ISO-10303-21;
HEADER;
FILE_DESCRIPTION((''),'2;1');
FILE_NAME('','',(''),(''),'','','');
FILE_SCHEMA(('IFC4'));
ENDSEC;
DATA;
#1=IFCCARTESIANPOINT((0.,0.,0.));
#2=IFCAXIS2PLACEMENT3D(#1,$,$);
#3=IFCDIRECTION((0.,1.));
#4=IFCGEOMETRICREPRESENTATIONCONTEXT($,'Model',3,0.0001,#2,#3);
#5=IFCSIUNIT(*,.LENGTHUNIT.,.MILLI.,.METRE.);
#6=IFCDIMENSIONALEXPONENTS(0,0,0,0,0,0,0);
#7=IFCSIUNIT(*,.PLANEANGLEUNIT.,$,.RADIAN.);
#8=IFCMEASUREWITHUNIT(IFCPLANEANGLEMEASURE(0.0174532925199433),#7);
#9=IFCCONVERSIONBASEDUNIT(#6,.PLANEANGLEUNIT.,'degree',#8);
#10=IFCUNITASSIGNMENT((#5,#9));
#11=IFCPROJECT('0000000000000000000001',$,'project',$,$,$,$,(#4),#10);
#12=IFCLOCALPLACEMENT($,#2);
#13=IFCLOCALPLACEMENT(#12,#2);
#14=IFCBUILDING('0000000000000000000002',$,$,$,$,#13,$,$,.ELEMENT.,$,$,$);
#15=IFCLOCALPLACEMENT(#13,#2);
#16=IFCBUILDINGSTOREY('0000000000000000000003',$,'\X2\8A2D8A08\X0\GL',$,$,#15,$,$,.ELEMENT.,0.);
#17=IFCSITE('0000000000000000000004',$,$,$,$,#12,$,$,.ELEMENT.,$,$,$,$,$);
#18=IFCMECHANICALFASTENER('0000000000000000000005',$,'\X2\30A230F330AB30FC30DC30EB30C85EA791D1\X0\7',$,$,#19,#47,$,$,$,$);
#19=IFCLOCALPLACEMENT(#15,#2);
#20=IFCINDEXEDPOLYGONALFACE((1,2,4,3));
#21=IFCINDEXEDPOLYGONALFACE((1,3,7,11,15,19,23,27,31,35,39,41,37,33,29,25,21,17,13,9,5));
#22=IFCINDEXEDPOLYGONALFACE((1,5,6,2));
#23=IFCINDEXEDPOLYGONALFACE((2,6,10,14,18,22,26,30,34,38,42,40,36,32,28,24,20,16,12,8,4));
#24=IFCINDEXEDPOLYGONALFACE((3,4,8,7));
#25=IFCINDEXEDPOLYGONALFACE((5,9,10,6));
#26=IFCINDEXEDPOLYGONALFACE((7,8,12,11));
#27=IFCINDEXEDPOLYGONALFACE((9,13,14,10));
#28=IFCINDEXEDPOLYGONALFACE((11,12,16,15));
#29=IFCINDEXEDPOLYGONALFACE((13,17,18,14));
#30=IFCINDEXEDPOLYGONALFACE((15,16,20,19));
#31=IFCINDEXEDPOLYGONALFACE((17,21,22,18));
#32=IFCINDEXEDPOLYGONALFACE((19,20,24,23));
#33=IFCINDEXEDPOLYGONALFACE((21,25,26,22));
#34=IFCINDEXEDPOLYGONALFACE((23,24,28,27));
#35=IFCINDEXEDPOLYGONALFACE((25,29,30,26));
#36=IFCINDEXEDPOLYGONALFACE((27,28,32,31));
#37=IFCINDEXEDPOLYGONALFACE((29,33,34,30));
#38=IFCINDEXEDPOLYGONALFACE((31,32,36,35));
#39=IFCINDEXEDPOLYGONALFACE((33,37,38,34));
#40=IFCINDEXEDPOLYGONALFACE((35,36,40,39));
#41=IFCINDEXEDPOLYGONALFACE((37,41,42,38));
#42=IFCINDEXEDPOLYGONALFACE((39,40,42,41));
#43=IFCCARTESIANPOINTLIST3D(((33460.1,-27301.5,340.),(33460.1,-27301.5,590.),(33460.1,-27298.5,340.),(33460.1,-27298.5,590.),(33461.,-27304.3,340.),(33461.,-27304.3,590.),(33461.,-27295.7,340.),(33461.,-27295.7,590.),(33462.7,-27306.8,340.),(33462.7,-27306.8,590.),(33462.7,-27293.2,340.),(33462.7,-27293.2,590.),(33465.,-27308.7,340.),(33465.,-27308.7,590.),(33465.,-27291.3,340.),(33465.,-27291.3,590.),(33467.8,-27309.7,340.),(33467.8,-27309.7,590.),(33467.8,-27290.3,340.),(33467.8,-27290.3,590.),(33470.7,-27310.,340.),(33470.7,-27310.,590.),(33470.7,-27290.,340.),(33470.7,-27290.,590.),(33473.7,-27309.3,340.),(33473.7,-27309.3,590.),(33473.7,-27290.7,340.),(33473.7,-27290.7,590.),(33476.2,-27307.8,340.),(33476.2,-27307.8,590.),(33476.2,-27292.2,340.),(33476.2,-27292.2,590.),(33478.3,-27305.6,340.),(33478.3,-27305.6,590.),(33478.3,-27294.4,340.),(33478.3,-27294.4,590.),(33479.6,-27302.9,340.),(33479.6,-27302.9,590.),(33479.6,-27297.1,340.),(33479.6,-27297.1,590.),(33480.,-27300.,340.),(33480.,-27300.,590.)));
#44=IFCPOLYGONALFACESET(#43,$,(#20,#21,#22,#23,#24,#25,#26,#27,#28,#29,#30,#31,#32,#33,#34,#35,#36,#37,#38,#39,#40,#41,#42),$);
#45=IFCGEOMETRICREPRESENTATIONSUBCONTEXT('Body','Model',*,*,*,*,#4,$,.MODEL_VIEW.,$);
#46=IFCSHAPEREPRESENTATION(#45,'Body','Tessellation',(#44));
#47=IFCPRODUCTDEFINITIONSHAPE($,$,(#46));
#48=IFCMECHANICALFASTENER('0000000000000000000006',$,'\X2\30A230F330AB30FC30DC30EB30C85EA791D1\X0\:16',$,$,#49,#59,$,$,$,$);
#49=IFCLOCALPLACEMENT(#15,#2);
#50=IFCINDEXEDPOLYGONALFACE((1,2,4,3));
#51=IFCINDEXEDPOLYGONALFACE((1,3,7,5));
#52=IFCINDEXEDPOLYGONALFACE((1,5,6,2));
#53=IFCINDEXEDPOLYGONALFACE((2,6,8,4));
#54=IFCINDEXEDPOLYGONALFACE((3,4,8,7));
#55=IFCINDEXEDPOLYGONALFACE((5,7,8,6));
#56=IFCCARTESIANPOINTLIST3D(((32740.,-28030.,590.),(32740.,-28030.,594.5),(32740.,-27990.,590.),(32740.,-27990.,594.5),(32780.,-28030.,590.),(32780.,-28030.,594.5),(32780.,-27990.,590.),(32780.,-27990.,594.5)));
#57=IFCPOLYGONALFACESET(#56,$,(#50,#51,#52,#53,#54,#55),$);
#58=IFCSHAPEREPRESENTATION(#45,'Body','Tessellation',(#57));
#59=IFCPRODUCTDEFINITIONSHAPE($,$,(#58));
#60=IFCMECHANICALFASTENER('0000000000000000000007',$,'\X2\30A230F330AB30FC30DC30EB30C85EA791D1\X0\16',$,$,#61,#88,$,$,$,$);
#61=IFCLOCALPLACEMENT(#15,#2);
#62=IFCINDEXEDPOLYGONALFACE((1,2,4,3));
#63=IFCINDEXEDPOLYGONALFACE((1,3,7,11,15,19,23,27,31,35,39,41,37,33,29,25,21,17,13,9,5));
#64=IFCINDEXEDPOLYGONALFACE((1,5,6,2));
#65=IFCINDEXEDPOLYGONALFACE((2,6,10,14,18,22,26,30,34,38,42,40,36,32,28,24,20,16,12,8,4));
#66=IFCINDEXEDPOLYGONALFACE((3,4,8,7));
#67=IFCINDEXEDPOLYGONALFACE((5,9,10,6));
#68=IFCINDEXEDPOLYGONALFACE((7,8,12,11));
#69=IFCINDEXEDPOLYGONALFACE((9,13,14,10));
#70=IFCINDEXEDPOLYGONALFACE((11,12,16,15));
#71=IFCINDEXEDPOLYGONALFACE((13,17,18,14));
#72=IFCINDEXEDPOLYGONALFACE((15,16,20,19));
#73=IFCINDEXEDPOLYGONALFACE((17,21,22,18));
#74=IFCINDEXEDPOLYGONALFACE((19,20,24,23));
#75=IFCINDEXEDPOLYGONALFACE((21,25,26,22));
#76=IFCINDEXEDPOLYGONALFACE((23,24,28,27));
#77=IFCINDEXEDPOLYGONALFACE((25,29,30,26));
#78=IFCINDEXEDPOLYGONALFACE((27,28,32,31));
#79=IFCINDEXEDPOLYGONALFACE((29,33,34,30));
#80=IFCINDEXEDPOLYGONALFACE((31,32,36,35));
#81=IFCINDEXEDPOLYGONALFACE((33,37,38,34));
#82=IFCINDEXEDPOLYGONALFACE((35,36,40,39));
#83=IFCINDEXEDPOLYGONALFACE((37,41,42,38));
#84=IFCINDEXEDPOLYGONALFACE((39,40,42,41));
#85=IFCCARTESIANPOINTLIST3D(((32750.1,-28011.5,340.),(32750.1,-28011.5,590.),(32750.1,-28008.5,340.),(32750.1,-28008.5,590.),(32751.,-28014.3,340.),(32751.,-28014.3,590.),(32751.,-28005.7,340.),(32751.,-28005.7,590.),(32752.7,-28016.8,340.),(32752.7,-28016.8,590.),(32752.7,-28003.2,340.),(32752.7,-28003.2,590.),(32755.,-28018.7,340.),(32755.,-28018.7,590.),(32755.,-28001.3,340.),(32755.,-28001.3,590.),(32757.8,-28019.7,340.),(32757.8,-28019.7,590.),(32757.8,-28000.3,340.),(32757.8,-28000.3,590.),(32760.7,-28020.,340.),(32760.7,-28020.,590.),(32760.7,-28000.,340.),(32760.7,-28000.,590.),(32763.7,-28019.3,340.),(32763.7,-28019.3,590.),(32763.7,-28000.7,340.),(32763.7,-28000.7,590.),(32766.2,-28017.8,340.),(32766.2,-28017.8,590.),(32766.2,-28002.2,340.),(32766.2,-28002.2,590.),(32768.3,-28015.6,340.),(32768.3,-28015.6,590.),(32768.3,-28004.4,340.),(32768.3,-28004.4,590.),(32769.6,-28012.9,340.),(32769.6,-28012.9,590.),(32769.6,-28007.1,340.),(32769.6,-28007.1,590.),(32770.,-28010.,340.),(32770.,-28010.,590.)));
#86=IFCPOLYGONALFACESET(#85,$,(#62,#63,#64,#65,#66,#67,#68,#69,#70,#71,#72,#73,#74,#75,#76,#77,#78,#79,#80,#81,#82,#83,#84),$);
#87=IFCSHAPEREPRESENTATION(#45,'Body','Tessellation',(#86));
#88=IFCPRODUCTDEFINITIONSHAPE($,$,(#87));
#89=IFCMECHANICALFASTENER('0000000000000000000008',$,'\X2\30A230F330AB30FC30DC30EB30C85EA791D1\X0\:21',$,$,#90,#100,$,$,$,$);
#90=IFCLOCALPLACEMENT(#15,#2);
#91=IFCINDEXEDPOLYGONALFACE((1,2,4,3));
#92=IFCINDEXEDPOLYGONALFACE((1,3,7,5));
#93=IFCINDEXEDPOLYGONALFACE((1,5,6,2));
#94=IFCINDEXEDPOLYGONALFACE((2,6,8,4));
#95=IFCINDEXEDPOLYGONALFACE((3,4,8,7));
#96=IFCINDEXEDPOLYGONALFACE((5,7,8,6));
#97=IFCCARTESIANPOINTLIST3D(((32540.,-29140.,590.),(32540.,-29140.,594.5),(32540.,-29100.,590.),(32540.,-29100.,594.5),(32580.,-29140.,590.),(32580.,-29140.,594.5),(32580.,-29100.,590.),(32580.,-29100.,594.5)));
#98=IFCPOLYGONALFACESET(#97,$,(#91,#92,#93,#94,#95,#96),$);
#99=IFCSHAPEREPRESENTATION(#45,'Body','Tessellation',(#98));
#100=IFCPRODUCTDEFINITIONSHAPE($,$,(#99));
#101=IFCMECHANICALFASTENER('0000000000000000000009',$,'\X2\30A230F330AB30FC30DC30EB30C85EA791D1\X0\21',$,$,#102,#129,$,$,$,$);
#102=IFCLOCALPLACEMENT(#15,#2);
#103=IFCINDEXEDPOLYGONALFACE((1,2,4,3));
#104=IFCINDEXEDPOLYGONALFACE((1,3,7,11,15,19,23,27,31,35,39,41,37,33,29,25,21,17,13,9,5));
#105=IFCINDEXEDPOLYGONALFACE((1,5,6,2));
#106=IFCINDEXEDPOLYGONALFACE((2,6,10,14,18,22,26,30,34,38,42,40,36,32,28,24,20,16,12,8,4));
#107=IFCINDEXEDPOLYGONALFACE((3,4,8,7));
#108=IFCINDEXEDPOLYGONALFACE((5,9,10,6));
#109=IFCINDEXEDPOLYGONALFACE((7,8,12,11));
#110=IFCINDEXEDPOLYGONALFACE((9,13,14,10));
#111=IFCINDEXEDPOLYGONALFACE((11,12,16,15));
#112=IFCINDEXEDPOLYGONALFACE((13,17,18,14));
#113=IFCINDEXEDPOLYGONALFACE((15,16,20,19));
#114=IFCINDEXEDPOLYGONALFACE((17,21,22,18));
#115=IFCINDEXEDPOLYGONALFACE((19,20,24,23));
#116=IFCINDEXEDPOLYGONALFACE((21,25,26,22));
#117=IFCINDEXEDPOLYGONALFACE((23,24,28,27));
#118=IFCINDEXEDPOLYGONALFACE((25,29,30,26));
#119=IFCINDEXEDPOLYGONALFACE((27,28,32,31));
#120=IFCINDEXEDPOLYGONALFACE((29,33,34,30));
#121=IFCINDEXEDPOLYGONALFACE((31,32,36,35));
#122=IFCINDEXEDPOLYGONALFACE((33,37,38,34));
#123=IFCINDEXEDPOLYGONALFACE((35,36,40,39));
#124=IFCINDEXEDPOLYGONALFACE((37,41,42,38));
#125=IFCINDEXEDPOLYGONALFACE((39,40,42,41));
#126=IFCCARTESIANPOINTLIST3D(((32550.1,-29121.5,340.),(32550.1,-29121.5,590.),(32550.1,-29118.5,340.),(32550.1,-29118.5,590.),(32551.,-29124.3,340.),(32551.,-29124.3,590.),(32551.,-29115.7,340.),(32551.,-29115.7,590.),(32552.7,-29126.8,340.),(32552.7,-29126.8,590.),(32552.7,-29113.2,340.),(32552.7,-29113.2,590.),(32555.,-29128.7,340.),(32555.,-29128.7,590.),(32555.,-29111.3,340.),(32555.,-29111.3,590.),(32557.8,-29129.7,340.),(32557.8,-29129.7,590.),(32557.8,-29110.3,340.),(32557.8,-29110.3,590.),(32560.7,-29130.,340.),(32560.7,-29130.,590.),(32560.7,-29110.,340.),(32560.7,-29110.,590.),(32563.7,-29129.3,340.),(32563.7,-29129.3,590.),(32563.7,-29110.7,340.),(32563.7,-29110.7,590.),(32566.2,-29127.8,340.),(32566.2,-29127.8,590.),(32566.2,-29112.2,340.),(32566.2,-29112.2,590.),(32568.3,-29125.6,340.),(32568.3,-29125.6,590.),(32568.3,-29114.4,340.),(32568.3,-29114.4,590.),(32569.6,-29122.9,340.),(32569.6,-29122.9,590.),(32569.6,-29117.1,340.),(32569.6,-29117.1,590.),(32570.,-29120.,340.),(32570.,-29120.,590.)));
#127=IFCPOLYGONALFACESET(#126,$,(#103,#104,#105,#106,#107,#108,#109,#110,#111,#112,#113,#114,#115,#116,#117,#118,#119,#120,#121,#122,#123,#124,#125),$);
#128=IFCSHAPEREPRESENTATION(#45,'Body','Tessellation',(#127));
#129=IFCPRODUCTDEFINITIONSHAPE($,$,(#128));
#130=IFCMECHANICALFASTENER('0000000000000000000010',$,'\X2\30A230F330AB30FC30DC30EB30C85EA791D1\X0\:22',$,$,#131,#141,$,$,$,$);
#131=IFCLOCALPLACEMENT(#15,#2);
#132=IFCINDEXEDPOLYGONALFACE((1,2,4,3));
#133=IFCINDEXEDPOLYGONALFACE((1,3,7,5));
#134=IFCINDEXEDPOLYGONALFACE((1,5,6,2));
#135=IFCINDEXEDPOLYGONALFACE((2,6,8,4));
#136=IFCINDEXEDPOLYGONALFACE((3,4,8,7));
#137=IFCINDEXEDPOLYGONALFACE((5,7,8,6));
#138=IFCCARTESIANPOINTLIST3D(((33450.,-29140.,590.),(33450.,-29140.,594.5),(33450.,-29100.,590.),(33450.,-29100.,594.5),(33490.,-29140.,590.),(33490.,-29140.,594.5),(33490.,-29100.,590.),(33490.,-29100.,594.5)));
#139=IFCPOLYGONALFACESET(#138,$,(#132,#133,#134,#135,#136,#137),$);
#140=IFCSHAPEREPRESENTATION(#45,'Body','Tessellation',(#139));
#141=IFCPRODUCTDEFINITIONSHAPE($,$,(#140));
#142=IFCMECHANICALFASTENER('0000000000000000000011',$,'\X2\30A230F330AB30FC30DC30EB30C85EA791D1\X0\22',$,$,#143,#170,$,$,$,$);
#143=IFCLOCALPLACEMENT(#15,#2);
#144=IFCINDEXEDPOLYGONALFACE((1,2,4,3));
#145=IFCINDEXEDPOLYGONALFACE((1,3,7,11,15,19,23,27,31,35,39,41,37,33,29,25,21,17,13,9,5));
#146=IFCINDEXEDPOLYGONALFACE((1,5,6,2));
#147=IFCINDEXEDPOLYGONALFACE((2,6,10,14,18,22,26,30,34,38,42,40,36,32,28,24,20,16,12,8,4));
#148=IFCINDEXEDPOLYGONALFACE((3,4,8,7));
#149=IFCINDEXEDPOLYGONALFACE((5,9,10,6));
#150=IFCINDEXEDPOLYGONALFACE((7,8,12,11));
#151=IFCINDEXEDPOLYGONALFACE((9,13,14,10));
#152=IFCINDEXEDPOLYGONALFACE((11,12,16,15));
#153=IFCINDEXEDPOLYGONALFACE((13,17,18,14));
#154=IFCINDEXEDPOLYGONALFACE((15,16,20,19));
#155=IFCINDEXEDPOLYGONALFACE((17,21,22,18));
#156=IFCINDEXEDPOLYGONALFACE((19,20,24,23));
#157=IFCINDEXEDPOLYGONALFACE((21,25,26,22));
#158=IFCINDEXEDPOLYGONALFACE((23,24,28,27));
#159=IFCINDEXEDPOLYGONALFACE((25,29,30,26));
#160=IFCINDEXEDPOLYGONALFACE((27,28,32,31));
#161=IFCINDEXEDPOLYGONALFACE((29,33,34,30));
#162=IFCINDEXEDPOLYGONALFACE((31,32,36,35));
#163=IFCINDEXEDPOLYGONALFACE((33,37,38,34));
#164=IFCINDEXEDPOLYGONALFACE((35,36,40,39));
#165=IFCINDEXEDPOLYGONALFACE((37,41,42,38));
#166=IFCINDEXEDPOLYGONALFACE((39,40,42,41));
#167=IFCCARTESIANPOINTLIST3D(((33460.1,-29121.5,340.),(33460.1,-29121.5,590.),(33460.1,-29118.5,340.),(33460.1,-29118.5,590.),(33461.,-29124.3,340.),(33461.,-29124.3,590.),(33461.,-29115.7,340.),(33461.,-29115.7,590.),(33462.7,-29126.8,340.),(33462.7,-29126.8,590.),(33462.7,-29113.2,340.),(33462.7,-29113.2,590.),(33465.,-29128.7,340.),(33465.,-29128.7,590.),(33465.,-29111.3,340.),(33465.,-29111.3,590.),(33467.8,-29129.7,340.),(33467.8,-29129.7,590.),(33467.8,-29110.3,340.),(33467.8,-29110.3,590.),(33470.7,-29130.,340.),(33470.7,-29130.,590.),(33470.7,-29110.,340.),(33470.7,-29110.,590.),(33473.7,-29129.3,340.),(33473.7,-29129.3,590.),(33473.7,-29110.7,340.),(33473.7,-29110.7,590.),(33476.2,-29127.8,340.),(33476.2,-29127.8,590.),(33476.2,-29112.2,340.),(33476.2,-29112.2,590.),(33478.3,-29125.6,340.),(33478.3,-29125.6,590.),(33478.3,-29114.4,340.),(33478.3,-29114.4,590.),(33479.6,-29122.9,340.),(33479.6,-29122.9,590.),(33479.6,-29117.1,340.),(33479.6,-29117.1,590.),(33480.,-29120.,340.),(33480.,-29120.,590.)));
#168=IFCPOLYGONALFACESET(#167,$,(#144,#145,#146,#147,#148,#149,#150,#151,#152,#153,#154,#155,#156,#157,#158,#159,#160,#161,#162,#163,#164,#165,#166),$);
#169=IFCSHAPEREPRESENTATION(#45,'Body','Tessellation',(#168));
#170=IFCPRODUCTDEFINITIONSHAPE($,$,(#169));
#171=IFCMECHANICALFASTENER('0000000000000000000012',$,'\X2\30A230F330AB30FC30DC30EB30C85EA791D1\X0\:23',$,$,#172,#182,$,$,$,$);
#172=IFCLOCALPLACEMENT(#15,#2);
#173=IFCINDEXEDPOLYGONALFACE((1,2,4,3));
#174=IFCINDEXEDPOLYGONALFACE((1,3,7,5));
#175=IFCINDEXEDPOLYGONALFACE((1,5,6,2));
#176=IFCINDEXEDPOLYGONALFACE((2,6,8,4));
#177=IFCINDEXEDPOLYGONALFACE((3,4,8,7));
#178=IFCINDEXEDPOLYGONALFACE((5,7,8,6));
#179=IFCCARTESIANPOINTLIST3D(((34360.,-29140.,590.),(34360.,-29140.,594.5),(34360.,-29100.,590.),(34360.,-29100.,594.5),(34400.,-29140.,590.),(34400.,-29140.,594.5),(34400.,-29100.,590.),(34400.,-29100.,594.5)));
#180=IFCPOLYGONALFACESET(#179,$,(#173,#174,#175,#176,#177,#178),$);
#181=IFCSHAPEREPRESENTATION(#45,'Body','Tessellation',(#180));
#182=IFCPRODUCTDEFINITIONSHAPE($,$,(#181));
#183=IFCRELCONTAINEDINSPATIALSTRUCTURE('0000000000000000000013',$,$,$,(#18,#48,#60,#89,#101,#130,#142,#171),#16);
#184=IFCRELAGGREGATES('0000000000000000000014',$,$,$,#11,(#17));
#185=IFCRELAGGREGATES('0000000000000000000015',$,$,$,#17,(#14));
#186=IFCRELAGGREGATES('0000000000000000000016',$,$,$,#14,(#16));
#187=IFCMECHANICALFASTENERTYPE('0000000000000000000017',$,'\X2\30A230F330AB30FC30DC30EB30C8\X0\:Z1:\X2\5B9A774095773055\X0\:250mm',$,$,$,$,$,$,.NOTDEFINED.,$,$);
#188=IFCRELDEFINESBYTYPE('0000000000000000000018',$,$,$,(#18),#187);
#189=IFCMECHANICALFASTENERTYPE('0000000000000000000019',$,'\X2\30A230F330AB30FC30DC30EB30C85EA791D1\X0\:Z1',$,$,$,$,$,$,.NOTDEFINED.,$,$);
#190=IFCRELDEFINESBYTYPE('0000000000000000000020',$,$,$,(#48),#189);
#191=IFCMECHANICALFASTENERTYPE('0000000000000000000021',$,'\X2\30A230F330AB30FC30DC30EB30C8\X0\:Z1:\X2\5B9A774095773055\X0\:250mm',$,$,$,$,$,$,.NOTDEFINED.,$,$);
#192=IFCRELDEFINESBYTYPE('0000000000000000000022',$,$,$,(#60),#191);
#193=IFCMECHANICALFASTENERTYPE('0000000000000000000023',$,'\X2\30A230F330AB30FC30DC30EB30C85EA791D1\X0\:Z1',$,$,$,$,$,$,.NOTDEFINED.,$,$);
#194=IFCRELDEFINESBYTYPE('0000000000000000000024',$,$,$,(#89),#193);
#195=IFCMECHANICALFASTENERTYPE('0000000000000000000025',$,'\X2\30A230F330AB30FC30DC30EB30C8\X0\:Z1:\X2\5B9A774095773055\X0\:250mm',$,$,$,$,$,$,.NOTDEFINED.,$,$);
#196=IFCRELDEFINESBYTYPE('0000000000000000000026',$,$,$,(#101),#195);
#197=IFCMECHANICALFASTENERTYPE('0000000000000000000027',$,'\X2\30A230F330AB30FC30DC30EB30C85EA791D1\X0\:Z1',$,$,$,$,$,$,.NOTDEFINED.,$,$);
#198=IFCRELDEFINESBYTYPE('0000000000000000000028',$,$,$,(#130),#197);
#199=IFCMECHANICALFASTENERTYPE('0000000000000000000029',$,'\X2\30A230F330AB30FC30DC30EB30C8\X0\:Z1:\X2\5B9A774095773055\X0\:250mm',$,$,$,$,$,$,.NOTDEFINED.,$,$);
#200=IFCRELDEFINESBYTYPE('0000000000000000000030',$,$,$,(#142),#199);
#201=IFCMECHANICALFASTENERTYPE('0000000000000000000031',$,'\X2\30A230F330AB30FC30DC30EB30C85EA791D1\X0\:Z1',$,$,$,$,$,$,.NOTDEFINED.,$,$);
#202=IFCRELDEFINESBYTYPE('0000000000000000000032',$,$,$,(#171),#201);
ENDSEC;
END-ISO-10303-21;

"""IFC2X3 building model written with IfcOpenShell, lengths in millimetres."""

from ifc_helpers import new_model, entity, si_unit, converted_unit, direction, frame, origin, origin_with_axes, origin_2d, place, context, subcontext, project, spatial, rectangle, circle, extrude, type_object, element, save


model = new_model("IFC2X3")

# Units and contexts
model_context = context("Model", 3, precision=0.0001, world=origin(), true_north=direction((0.0, 1.0)))
body_context = subcontext(model_context, "Body", "Model", "MODEL_VIEW")
ifc_project = project(units=[si_unit("LENGTHUNIT", "METRE", prefix="MILLI"), converted_unit("PLANEANGLEUNIT", "degree", entity("IfcPlaneAngleMeasure", 0.0174532925199433), si_unit("PLANEANGLEUNIT", "RADIAN"), dimensions=[0, 0, 0, 0, 0, 0, 0])], contexts=[model_context])

# Site, building, storey
site_placement = place(None, origin())
site = spatial("IfcSite", under=ifc_project, at=site_placement, CompositionType="ELEMENT")
building_placement = place(site_placement, origin())
building = spatial("IfcBuilding", under=site, at=building_placement, CompositionType="ELEMENT")
storey_placement = place(building_placement, origin())
storey = spatial("IfcBuildingStorey", under=building, at=storey_placement, Name="設計GL", CompositionType="ELEMENT", Elevation=0.0)

# Mechanical fasteners
mechanical_fastener_type_1 = type_object("IfcMechanicalFastenerType", Name="アンカーボルト:Z1:定着長さ:250mm")
mechanical_fastener_1_placement = place(storey_placement, frame((33470.0, -27300.0, 340.0)))
element("IfcMechanicalFastener", 1, at=mechanical_fastener_1_placement, inside=storey, type_object=mechanical_fastener_type_1, Name="アンカーボルト座金7", context=body_context, shape_type="SweptSolid", body=[
    extrude(circle(Radius=10.0, at=origin_2d()), origin_with_axes(), (0.0, 0.0, 1.0), 250.0),
])
mechanical_fastener_type_2 = type_object("IfcMechanicalFastenerType", Name="アンカーボルト座金:Z1")
mechanical_fastener_2_placement = place(storey_placement, frame((32760.0, -28010.0, 590.0)))
element("IfcMechanicalFastener", 2, at=mechanical_fastener_2_placement, inside=storey, type_object=mechanical_fastener_type_2, Name="アンカーボルト座金:16", context=body_context, shape_type="SweptSolid", body=[
    extrude(rectangle(XDim=40.0, YDim=40.0, at=origin_2d()), origin_with_axes(), (0.0, 0.0, 1.0), 4.5),
])
mechanical_fastener_type_3 = type_object("IfcMechanicalFastenerType", Name="アンカーボルト:Z1:定着長さ:250mm")
mechanical_fastener_3_placement = place(storey_placement, frame((32760.0, -28010.0, 340.0)))
element("IfcMechanicalFastener", 3, at=mechanical_fastener_3_placement, inside=storey, type_object=mechanical_fastener_type_3, Name="アンカーボルト座金16", context=body_context, shape_type="SweptSolid", body=[
    extrude(circle(Radius=10.0, at=origin_2d()), origin_with_axes(), (0.0, 0.0, 1.0), 250.0),
])
mechanical_fastener_type_4 = type_object("IfcMechanicalFastenerType", Name="アンカーボルト座金:Z1")
mechanical_fastener_4_placement = place(storey_placement, frame((32560.0, -29120.0, 590.0)))
element("IfcMechanicalFastener", 4, at=mechanical_fastener_4_placement, inside=storey, type_object=mechanical_fastener_type_4, Name="アンカーボルト座金:21", context=body_context, shape_type="SweptSolid", body=[
    extrude(rectangle(XDim=40.0, YDim=40.0, at=origin_2d()), origin_with_axes(), (0.0, 0.0, 1.0), 4.5),
])
mechanical_fastener_type_5 = type_object("IfcMechanicalFastenerType", Name="アンカーボルト:Z1:定着長さ:250mm")
mechanical_fastener_5_placement = place(storey_placement, frame((32560.0, -29120.0, 340.0)))
element("IfcMechanicalFastener", 5, at=mechanical_fastener_5_placement, inside=storey, type_object=mechanical_fastener_type_5, Name="アンカーボルト座金21", context=body_context, shape_type="SweptSolid", body=[
    extrude(circle(Radius=10.0, at=origin_2d()), origin_with_axes(), (0.0, 0.0, 1.0), 250.0),
])
mechanical_fastener_type_6 = type_object("IfcMechanicalFastenerType", Name="アンカーボルト座金:Z1")
mechanical_fastener_6_placement = place(storey_placement, frame((33470.0, -29120.0, 590.0)))
element("IfcMechanicalFastener", 6, at=mechanical_fastener_6_placement, inside=storey, type_object=mechanical_fastener_type_6, Name="アンカーボルト座金:22", context=body_context, shape_type="SweptSolid", body=[
    extrude(rectangle(XDim=40.0, YDim=40.0, at=origin_2d()), origin_with_axes(), (0.0, 0.0, 1.0), 4.5),
])
mechanical_fastener_type_7 = type_object("IfcMechanicalFastenerType", Name="アンカーボルト:Z1:定着長さ:250mm")
mechanical_fastener_7_placement = place(storey_placement, frame((33470.0, -29120.0, 340.0)))
element("IfcMechanicalFastener", 7, at=mechanical_fastener_7_placement, inside=storey, type_object=mechanical_fastener_type_7, Name="アンカーボルト座金22", context=body_context, shape_type="SweptSolid", body=[
    extrude(circle(Radius=10.0, at=origin_2d()), origin_with_axes(), (0.0, 0.0, 1.0), 250.0),
])
mechanical_fastener_type_8 = type_object("IfcMechanicalFastenerType", Name="アンカーボルト座金:Z1")
mechanical_fastener_8_placement = place(storey_placement, frame((34380.0, -29120.0, 590.0)))
element("IfcMechanicalFastener", 8, at=mechanical_fastener_8_placement, inside=storey, type_object=mechanical_fastener_type_8, Name="アンカーボルト座金:23", context=body_context, shape_type="SweptSolid", body=[
    extrude(rectangle(XDim=40.0, YDim=40.0, at=origin_2d()), origin_with_axes(), (0.0, 0.0, 1.0), 4.5),
])

save(model, "model.ifc")
